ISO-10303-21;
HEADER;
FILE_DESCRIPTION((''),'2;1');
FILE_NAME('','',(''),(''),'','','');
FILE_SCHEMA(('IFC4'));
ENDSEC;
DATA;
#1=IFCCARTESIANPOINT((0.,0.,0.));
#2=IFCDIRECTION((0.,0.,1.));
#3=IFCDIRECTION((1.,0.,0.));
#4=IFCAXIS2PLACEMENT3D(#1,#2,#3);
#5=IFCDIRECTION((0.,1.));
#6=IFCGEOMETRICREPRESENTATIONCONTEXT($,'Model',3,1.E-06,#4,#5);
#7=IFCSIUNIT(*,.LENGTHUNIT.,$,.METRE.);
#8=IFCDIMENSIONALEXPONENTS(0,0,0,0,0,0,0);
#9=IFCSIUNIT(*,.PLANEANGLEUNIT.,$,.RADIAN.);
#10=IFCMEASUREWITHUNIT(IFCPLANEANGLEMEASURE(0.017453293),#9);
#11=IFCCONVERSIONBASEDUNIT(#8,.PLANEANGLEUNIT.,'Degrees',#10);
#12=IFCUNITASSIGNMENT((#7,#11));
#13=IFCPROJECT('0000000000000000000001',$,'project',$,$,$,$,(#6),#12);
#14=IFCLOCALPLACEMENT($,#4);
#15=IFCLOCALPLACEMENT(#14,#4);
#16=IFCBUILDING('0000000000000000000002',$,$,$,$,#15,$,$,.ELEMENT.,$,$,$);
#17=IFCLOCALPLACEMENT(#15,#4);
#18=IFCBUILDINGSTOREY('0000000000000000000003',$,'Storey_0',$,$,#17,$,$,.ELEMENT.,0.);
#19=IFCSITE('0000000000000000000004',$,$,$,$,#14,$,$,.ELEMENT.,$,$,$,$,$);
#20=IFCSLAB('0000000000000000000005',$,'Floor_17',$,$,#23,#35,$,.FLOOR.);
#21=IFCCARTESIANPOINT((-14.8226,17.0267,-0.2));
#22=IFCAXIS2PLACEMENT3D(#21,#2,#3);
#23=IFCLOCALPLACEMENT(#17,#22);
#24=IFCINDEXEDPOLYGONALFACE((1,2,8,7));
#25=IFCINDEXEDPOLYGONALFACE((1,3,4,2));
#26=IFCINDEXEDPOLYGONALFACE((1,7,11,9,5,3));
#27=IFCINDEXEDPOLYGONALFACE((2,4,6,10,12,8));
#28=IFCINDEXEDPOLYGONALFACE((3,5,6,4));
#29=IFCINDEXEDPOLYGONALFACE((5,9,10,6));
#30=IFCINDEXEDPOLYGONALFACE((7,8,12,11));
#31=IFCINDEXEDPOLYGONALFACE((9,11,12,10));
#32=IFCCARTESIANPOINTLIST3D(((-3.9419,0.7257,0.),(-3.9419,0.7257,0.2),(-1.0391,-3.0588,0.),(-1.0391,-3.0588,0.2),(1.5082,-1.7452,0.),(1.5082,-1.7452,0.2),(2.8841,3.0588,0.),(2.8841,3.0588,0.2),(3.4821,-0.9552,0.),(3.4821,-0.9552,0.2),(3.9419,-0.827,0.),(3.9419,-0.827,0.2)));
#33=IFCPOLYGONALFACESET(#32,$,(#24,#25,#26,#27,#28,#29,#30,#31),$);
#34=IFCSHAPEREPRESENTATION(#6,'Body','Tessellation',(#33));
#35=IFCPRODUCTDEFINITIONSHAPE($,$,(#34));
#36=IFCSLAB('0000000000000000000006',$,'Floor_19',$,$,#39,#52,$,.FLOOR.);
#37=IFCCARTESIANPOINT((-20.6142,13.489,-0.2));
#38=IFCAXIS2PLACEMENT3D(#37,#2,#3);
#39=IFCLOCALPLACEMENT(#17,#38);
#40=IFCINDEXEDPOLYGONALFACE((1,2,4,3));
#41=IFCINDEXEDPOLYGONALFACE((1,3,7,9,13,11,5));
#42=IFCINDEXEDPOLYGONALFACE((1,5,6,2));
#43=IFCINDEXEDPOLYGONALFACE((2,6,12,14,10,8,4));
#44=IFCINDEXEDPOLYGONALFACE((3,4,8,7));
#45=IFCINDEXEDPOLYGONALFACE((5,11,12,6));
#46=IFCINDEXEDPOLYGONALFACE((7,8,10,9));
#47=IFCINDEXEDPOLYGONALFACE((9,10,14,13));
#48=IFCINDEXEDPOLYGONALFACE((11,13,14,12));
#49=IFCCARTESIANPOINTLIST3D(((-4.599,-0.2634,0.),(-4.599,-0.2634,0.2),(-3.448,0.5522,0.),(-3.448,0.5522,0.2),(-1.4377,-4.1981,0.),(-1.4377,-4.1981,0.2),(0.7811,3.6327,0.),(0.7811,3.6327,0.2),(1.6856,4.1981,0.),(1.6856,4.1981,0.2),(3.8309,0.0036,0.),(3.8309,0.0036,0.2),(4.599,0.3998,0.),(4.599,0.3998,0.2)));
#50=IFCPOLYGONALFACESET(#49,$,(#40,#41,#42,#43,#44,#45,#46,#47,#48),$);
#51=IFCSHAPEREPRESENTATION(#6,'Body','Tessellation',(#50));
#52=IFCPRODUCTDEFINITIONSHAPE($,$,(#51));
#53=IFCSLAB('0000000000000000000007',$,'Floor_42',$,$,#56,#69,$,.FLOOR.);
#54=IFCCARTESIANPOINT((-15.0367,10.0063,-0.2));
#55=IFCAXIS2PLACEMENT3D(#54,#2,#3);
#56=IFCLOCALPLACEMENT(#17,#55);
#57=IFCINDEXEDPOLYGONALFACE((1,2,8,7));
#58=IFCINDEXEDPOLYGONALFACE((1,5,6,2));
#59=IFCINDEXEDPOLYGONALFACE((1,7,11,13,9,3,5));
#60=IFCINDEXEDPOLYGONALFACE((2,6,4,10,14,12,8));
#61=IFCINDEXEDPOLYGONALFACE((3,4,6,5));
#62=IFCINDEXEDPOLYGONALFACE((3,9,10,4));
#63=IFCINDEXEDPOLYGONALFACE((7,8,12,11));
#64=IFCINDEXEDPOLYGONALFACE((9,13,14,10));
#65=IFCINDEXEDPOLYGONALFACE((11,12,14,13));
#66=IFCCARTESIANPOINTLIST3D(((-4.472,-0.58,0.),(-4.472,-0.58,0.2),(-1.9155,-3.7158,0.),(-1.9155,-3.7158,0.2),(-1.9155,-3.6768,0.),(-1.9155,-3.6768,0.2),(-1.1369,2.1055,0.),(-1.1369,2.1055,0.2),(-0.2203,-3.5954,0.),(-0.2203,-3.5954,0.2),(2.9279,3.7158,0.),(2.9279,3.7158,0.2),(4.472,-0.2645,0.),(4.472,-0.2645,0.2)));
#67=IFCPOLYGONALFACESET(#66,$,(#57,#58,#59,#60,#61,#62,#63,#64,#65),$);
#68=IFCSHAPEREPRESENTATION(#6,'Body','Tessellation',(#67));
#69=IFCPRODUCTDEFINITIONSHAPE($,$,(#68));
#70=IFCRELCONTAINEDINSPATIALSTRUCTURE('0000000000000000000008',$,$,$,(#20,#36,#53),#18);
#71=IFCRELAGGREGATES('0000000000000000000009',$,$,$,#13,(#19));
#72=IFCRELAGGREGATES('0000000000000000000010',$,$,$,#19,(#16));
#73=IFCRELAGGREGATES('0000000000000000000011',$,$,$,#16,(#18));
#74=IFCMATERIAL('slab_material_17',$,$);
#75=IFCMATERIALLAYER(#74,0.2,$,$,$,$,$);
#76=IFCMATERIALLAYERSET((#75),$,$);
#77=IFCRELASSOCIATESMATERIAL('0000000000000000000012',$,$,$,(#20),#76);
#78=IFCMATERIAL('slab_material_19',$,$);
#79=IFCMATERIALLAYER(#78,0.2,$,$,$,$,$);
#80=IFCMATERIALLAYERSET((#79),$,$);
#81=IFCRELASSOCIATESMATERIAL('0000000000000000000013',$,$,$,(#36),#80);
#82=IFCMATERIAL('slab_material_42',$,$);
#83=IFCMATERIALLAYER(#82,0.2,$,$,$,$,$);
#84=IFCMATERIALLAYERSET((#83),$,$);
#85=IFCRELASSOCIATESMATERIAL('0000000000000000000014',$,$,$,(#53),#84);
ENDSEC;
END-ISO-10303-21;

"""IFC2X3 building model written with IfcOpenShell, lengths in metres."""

from ifc_helpers import new_model, entity, si_unit, converted_unit, direction, frame, origin_with_axes, place, context, project, spatial, polyline, outline, extrude, material, layer, layer_set, layer_usage, element, save


model = new_model("IFC2X3")

# Units and contexts
model_context = context("Model", 3, precision=1e-06, world=origin_with_axes(), true_north=direction((0.0, 1.0)))
ifc_project = project(units=[si_unit("LENGTHUNIT", "METRE"), converted_unit("PLANEANGLEUNIT", "Degrees", entity("IfcPlaneAngleMeasure", 0.017453293), si_unit("PLANEANGLEUNIT", "RADIAN"), dimensions=[0, 0, 0, 0, 0, 0, 0])], contexts=[model_context])

# Site, building, storey
site_placement = place(None, origin_with_axes())
site = spatial("IfcSite", under=ifc_project, at=site_placement, CompositionType="ELEMENT")
building_placement = place(site_placement, origin_with_axes())
building = spatial("IfcBuilding", under=site, at=building_placement, CompositionType="ELEMENT")
storey_placement = place(building_placement, origin_with_axes())
storey = spatial("IfcBuildingStorey", under=building, at=storey_placement, Name="Storey_0", CompositionType="ELEMENT", Elevation=0.0)

# Slabs
ifc_material_1 = material(Name="slab_material_17")
ifc_layer_1 = layer(ifc_material_1, 0.2)
ifc_layer_set_1 = layer_set([ifc_layer_1])
ifc_layer_usage_1 = layer_usage(ifc_layer_set_1, "AXIS3", "POSITIVE", 0.0)
slab_1_placement = place(storey_placement, frame((-14.8226, 17.0267, -0.2), z_axis=(0.0, 0.0, 1.0), x_axis=(1.0, 0.0, 0.0)))
element("IfcSlab", 1, at=slab_1_placement, inside=storey, material=ifc_layer_usage_1, Name="Floor_17", PredefinedType="FLOOR", context=model_context, shape_type="SweptSolid", body=[
    extrude(outline(polyline([(3.9419, -0.827), (3.4821, -0.9552), (1.5082, -1.7452), (-1.0391, -3.0587), (-3.9419, 0.7257), (2.8841, 3.0587), (3.9419, -0.827)])), origin_with_axes(), (0.0, 0.0, 1.0), 0.2),
])
ifc_material_2 = material(Name="slab_material_19")
ifc_layer_2 = layer(ifc_material_2, 0.2)
ifc_layer_set_2 = layer_set([ifc_layer_2])
ifc_layer_usage_2 = layer_usage(ifc_layer_set_2, "AXIS3", "POSITIVE", 0.0)
slab_2_placement = place(storey_placement, frame((-20.6142, 13.489, -0.2), z_axis=(0.0, 0.0, 1.0), x_axis=(1.0, 0.0, 0.0)))
element("IfcSlab", 2, at=slab_2_placement, inside=storey, material=ifc_layer_usage_2, Name="Floor_19", PredefinedType="FLOOR", context=model_context, shape_type="SweptSolid", body=[
    extrude(outline(polyline([(4.599, 0.3998), (3.8309, 0.0036), (-1.4377, -4.1981), (-4.599, -0.2634), (-3.448, 0.5522), (0.7811, 3.6327), (1.6856, 4.1981), (4.599, 0.3998)])), origin_with_axes(), (0.0, 0.0, 1.0), 0.2),
])
ifc_material_3 = material(Name="slab_material_42")
ifc_layer_3 = layer(ifc_material_3, 0.2)
ifc_layer_set_3 = layer_set([ifc_layer_3])
ifc_layer_usage_3 = layer_usage(ifc_layer_set_3, "AXIS3", "POSITIVE", 0.0)
slab_3_placement = place(storey_placement, frame((-15.0367, 10.0063, -0.2), z_axis=(0.0, 0.0, 1.0), x_axis=(1.0, 0.0, 0.0)))
element("IfcSlab", 3, at=slab_3_placement, inside=storey, material=ifc_layer_usage_3, Name="Floor_42", PredefinedType="FLOOR", context=model_context, shape_type="SweptSolid", body=[
    extrude(outline(polyline([(-1.1369, 2.1055), (2.9279, 3.7158), (4.472, -0.2645), (-0.2203, -3.5954), (-1.9155, -3.7158), (-1.9155, -3.6768), (-4.472, -0.58), (-1.1369, 2.1055)])), origin_with_axes(), (0.0, 0.0, 1.0), 0.2),
])

save(model, "model.ifc")
